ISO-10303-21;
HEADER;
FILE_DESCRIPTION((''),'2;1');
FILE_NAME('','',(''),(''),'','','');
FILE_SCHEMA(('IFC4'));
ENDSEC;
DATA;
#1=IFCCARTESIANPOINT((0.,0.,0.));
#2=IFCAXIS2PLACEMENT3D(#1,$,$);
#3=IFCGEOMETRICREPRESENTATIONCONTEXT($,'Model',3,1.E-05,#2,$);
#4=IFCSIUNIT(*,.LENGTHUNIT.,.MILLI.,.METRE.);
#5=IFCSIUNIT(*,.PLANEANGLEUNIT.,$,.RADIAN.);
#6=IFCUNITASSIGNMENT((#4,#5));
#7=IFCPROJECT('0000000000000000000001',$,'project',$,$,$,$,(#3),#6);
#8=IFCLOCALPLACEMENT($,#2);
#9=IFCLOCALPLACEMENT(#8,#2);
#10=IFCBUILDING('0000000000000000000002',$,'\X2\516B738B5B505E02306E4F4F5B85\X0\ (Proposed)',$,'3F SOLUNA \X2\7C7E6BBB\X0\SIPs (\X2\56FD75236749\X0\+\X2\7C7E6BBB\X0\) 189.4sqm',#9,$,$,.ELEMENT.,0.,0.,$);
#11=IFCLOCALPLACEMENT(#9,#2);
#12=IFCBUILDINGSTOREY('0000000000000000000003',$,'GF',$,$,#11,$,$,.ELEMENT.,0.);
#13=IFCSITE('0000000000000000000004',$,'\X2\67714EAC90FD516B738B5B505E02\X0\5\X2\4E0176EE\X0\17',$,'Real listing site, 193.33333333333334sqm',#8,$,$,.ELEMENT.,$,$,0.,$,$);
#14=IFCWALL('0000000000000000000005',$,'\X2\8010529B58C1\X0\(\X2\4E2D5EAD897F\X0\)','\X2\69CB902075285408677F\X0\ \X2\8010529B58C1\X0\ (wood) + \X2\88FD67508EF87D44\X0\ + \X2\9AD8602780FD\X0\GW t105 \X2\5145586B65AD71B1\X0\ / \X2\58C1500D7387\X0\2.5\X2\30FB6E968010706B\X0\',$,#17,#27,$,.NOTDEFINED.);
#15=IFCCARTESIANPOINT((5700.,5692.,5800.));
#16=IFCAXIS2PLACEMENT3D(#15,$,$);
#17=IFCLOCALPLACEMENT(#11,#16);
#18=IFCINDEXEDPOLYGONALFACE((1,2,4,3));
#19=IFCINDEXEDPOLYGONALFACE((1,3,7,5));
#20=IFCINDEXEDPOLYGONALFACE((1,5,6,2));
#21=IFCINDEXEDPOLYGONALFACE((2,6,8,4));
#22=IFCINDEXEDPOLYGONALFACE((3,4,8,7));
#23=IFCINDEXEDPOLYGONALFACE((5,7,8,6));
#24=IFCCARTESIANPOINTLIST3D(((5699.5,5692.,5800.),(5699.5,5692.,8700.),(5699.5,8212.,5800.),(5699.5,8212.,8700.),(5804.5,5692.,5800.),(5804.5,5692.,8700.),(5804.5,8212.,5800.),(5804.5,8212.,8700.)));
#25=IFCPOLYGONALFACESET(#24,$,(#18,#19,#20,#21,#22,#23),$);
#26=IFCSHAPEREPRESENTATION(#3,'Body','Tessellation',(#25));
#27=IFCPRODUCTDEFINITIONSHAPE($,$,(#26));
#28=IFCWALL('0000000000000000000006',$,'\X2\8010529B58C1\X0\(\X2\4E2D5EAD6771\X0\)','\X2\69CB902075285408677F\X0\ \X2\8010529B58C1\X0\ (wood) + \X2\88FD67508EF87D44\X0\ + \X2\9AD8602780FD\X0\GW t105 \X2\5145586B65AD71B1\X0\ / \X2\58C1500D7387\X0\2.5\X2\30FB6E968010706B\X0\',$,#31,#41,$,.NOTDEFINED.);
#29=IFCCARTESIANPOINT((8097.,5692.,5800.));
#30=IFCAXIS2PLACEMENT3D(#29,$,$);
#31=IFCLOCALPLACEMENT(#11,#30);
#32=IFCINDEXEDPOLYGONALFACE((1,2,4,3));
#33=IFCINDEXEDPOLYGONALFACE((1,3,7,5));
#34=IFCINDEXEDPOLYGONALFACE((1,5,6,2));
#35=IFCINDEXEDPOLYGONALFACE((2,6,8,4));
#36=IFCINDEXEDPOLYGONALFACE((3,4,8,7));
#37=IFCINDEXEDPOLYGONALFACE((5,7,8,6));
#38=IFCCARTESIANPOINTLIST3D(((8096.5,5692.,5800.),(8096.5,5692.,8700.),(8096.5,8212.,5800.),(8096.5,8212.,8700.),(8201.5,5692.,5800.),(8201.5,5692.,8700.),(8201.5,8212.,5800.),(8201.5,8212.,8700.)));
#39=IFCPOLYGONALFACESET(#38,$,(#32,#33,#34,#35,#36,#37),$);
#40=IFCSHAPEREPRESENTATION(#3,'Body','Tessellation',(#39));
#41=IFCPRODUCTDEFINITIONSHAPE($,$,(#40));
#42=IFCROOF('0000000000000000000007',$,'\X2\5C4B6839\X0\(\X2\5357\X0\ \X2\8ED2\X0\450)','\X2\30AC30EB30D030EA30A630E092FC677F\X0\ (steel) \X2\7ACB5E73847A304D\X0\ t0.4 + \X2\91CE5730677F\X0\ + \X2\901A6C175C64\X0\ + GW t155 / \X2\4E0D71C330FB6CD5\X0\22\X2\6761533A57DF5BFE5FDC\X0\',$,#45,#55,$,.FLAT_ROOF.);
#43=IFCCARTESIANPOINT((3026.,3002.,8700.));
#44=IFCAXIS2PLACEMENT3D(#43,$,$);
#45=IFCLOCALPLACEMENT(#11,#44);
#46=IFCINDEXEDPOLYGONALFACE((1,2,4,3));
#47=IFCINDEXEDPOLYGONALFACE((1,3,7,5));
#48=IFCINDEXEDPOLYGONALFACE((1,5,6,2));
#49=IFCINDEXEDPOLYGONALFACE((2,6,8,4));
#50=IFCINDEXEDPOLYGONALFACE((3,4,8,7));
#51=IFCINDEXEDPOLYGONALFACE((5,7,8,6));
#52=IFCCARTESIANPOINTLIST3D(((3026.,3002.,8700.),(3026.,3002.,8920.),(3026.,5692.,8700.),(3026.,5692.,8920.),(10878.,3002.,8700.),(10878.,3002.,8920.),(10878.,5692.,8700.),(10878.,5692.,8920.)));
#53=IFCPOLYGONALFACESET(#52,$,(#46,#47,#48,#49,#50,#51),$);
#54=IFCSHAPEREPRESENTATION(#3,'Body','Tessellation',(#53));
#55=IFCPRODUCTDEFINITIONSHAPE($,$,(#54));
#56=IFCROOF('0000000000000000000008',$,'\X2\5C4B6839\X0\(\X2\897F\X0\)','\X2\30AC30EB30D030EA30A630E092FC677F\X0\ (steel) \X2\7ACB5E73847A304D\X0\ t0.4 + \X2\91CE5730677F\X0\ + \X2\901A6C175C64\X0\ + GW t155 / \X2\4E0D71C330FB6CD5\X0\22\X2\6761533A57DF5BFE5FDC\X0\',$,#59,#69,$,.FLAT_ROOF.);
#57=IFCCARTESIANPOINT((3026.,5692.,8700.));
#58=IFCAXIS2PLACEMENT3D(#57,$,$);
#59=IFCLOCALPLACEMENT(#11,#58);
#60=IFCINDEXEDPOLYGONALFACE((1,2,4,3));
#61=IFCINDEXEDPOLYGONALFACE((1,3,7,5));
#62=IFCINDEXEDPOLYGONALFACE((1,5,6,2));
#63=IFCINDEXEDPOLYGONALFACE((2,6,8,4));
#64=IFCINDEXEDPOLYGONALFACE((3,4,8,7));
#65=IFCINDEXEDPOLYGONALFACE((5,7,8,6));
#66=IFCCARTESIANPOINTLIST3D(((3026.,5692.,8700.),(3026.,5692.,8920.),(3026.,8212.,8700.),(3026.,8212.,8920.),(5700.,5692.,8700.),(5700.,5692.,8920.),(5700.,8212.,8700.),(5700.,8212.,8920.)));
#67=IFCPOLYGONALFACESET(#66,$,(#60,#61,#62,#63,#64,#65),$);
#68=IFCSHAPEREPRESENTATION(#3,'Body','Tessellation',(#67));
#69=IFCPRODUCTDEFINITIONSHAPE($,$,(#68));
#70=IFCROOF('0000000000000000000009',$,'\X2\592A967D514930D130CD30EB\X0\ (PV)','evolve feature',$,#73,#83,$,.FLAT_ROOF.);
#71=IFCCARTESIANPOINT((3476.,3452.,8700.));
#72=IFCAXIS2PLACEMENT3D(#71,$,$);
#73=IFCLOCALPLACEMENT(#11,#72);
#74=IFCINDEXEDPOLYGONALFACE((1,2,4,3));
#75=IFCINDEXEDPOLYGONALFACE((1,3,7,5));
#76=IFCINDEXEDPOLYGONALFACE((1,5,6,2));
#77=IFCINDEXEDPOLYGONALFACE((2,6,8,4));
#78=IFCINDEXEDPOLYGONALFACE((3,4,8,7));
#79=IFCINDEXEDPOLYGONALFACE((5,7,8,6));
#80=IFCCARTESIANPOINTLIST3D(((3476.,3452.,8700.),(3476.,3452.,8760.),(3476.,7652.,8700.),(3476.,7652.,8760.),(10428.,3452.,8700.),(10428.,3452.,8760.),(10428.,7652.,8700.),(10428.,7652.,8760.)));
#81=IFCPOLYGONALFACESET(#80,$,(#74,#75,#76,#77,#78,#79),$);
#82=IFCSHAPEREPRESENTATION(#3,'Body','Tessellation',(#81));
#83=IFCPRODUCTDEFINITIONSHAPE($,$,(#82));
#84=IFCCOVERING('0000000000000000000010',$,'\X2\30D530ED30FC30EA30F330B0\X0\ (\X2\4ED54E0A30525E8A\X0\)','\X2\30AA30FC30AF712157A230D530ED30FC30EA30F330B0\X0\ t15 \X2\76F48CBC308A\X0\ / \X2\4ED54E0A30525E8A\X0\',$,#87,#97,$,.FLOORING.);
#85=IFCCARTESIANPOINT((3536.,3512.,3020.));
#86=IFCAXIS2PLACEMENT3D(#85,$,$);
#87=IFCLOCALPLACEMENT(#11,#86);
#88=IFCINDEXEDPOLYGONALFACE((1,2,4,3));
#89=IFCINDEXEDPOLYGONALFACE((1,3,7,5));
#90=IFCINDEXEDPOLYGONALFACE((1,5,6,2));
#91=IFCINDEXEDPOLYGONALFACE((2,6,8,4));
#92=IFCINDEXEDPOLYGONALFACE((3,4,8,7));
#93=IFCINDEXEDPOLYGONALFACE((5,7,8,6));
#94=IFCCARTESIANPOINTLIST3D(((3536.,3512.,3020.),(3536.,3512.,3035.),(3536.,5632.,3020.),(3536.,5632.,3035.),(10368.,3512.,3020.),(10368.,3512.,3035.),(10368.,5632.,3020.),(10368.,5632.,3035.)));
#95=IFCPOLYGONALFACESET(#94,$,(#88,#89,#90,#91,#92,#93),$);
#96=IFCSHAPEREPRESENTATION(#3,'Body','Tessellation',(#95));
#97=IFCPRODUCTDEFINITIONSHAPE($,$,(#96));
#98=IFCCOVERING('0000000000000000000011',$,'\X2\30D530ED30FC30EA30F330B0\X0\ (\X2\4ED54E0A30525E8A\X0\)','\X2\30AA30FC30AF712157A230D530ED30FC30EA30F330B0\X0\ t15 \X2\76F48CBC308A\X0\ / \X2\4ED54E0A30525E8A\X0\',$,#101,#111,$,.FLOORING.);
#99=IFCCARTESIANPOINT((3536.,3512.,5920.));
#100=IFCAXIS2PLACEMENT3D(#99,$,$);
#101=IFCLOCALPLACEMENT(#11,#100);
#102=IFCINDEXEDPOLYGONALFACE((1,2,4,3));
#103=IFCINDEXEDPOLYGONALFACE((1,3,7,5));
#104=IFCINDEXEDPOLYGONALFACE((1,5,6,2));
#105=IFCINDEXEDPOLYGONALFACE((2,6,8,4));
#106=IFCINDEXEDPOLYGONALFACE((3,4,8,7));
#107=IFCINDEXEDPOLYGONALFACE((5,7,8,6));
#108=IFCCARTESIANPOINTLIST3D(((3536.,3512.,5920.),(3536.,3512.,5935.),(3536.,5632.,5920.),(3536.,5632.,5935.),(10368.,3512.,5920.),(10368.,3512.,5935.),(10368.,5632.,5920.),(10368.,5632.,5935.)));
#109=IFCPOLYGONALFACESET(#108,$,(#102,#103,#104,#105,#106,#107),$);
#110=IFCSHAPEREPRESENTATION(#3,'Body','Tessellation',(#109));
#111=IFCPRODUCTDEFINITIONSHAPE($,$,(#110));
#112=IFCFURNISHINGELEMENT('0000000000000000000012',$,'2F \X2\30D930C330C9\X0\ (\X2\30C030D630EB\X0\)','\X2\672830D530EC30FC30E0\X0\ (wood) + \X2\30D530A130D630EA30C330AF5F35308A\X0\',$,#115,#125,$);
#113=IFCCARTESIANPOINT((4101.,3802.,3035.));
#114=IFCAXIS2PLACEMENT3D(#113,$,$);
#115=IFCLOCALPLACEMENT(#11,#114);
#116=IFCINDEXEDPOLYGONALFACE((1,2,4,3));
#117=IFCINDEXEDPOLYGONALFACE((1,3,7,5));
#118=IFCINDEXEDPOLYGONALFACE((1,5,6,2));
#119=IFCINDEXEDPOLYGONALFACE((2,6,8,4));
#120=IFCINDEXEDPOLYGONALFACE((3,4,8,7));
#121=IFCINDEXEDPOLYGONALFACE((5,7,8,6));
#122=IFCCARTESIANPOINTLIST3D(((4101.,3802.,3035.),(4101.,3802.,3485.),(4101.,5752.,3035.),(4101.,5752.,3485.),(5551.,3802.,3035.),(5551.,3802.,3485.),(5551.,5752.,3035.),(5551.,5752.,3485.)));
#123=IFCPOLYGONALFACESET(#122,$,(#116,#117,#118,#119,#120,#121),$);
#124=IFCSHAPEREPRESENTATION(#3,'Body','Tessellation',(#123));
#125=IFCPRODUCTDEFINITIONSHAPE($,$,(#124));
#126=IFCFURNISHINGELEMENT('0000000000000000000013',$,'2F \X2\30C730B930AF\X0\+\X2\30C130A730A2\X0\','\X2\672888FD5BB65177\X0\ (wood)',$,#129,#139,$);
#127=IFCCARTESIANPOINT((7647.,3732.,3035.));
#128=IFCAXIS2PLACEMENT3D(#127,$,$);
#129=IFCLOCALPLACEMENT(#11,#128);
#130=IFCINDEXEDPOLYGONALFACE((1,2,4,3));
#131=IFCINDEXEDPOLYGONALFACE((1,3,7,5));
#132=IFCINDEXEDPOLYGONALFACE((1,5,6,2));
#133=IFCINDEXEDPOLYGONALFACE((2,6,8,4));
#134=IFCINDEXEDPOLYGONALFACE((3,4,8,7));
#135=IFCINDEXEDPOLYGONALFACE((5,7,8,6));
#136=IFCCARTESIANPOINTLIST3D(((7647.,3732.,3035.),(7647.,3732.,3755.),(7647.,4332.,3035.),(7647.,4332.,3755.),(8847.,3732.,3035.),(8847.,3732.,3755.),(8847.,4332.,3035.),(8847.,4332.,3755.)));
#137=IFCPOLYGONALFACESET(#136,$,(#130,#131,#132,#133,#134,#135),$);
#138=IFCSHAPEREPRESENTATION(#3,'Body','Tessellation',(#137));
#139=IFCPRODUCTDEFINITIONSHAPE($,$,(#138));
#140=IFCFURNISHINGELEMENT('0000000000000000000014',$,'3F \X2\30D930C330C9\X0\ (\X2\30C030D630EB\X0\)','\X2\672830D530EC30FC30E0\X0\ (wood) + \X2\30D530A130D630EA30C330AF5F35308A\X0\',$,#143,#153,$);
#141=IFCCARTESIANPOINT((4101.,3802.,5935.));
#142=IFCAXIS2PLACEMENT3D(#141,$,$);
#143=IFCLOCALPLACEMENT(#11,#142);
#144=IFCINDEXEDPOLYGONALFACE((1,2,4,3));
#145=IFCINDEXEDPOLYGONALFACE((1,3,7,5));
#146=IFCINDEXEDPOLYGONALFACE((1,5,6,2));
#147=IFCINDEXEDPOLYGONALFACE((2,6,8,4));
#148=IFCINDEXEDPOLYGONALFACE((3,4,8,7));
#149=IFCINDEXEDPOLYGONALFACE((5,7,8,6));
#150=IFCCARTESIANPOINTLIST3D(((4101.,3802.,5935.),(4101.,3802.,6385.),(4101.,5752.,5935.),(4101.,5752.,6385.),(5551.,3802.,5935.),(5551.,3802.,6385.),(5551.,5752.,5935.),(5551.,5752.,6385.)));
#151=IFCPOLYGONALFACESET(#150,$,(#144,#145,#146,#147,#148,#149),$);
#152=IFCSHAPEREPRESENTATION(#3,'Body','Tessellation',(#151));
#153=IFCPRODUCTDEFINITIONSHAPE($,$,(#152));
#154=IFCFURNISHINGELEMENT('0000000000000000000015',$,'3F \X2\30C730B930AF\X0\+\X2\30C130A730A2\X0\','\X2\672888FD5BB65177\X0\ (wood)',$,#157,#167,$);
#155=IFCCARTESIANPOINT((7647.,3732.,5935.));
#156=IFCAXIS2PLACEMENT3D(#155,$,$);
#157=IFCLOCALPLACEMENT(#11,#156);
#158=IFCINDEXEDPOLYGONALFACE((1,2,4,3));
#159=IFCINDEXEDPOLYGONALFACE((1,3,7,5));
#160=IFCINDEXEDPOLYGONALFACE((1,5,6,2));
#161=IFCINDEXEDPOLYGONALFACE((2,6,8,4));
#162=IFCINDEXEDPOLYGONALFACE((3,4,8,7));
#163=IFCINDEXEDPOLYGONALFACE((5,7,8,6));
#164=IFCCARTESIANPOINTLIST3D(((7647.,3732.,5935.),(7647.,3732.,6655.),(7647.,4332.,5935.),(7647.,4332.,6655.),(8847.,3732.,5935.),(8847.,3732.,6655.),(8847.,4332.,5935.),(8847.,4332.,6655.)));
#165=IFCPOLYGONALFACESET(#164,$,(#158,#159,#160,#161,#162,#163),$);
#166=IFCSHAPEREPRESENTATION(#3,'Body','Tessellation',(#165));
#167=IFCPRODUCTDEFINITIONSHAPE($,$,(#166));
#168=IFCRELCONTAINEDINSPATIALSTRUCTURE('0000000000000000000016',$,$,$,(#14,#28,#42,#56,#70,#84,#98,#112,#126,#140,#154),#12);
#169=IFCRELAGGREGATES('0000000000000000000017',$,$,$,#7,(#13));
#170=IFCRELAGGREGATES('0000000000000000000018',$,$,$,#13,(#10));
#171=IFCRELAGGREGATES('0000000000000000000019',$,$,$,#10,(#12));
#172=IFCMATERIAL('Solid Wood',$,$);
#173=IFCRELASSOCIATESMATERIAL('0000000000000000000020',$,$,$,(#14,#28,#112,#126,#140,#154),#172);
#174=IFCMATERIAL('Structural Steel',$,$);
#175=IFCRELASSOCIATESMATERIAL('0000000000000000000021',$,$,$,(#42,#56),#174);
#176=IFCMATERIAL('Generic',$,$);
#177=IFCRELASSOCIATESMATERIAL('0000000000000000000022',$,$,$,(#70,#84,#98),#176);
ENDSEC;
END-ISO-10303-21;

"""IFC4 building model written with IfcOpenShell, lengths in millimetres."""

from ifc_helpers import new_model, si_unit, frame, frame_2d, origin, place, context, project, spatial, rectangle, extrude, material, element, save


model = new_model("IFC4")

# Units and contexts
model_context = context("Model", 3, precision=1e-05, world=origin())
ifc_project = project(units=[si_unit("LENGTHUNIT", "METRE", prefix="MILLI"), si_unit("PLANEANGLEUNIT", "RADIAN")], contexts=[model_context])

# Site, building, storey
site_placement = place(None, origin())
site = spatial("IfcSite", under=ifc_project, at=site_placement, Name="東京都八王子市5丁目17", ObjectType="Real listing site, 193.33333333333334sqm", CompositionType="ELEMENT", RefElevation=0.0)
building_placement = place(site_placement, origin())
building = spatial("IfcBuilding", under=site, at=building_placement, Name="八王子市の住宅 (Proposed)", ObjectType="3F SOLUNA 籾殻SIPs (国産杉+籾殻) 189.4sqm", CompositionType="ELEMENT", ElevationOfRefHeight=0.0, ElevationOfTerrain=0.0)
storey_placement = place(building_placement, origin())
storey = spatial("IfcBuildingStorey", under=building, at=storey_placement, Name="GF", CompositionType="ELEMENT", Elevation=0.0)

# Shared definitions
ifc_material_1 = material(Name="Solid Wood")

# Walls
wall_1_placement = place(storey_placement, frame((5700.0, 5692.0, 5800.0)))
element("IfcWall", 1, at=wall_1_placement, inside=storey, material=ifc_material_1, Name="耐力壁(中庭西)", Description="構造用合板 耐力壁 (wood) + 製材軸組 + 高性能GW t105 充填断熱 / 壁倍率2.5・準耐火", PredefinedType="NOTDEFINED", context=model_context, shape_type="SweptSolid", body=[
    extrude(rectangle(XDim=105.0, YDim=2520.0, at=frame_2d((52.0, 1260.0))), frame((5700.0, 5692.0, 5800.0)), (0.0, 0.0, 1.0), 2900.0),
])
wall_2_placement = place(storey_placement, frame((8097.0, 5692.0, 5800.0)))
element("IfcWall", 2, at=wall_2_placement, inside=storey, material=ifc_material_1, Name="耐力壁(中庭東)", Description="構造用合板 耐力壁 (wood) + 製材軸組 + 高性能GW t105 充填断熱 / 壁倍率2.5・準耐火", PredefinedType="NOTDEFINED", context=model_context, shape_type="SweptSolid", body=[
    extrude(rectangle(XDim=105.0, YDim=2520.0, at=frame_2d((52.0, 1260.0))), frame((8097.0, 5692.0, 5800.0)), (0.0, 0.0, 1.0), 2900.0),
])

# Roofs
ifc_material_2 = material(Name="Structural Steel")
roof_1_placement = place(storey_placement, frame((3026.0, 3002.0, 8700.0)))
element("IfcRoof", 3, at=roof_1_placement, inside=storey, material=ifc_material_2, Name="屋根(南 軒450)", Description="ガルバリウム鋼板 (steel) 立平葺き t0.4 + 野地板 + 通気層 + GW t155 / 不燃・法22条区域対応", PredefinedType="FLAT_ROOF", context=model_context, shape_type="SweptSolid", body=[
    extrude(rectangle(XDim=7852.0, YDim=2690.0, at=frame_2d((3926.0, 1345.0))), frame((3026.0, 3002.0, 8700.0)), (0.0, 0.0, 1.0), 220.0),
])
roof_2_placement = place(storey_placement, frame((3026.0, 5692.0, 8700.0)))
element("IfcRoof", 4, at=roof_2_placement, inside=storey, material=ifc_material_2, Name="屋根(西)", Description="ガルバリウム鋼板 (steel) 立平葺き t0.4 + 野地板 + 通気層 + GW t155 / 不燃・法22条区域対応", PredefinedType="FLAT_ROOF", context=model_context, shape_type="SweptSolid", body=[
    extrude(rectangle(XDim=2674.0, YDim=2520.0, at=frame_2d((1337.0, 1260.0))), frame((3026.0, 5692.0, 8700.0)), (0.0, 0.0, 1.0), 220.0),
])
ifc_material_3 = material(Name="Generic")
roof_3_placement = place(storey_placement, frame((3476.0, 3452.0, 8700.0)))
element("IfcRoof", 5, at=roof_3_placement, inside=storey, material=ifc_material_3, Name="太陽光パネル (PV)", Description="evolve feature", PredefinedType="FLAT_ROOF", context=model_context, shape_type="SweptSolid", body=[
    extrude(rectangle(XDim=6952.0, YDim=4200.0, at=frame_2d((3476.0, 2100.0))), frame((3476.0, 3452.0, 8700.0)), (0.0, 0.0, 1.0), 60.0),
])

# Coverings
covering_1_placement = place(storey_placement, frame((3536.0, 3512.0, 3020.0)))
element("IfcCovering", 6, at=covering_1_placement, inside=storey, material=ifc_material_3, Name="フローリング (仕上げ床)", Description="オーク無垢フローリング t15 直貼り / 仕上げ床", PredefinedType="FLOORING", context=model_context, shape_type="SweptSolid", body=[
    extrude(rectangle(XDim=6832.0, YDim=2120.0, at=frame_2d((3416.0, 1060.0))), frame((3536.0, 3512.0, 3020.0)), (0.0, 0.0, 1.0), 15.0),
])
covering_2_placement = place(storey_placement, frame((3536.0, 3512.0, 5920.0)))
element("IfcCovering", 7, at=covering_2_placement, inside=storey, material=ifc_material_3, Name="フローリング (仕上げ床)", Description="オーク無垢フローリング t15 直貼り / 仕上げ床", PredefinedType="FLOORING", context=model_context, shape_type="SweptSolid", body=[
    extrude(rectangle(XDim=6832.0, YDim=2120.0, at=frame_2d((3416.0, 1060.0))), frame((3536.0, 3512.0, 5920.0)), (0.0, 0.0, 1.0), 15.0),
])

# Furnishing elements
furnishing_1_placement = place(storey_placement, frame((4101.0, 3802.0, 3035.0)))
element("IfcFurnishingElement", 8, at=furnishing_1_placement, inside=storey, material=ifc_material_1, Name="2F ベッド (ダブル)", Description="木フレーム (wood) + ファブリック張り", context=model_context, shape_type="SweptSolid", body=[
    extrude(rectangle(XDim=1450.0, YDim=1950.0, at=frame_2d((725.0, 975.0))), frame((4101.0, 3802.0, 3035.0)), (0.0, 0.0, 1.0), 450.0),
])
furnishing_2_placement = place(storey_placement, frame((7647.0, 3732.0, 3035.0)))
element("IfcFurnishingElement", 9, at=furnishing_2_placement, inside=storey, material=ifc_material_1, Name="2F デスク+チェア", Description="木製家具 (wood)", context=model_context, shape_type="SweptSolid", body=[
    extrude(rectangle(XDim=1200.0, YDim=600.0, at=frame_2d((600.0, 300.0))), frame((7647.0, 3732.0, 3035.0)), (0.0, 0.0, 1.0), 720.0),
])
furnishing_3_placement = place(storey_placement, frame((4101.0, 3802.0, 5935.0)))
element("IfcFurnishingElement", 10, at=furnishing_3_placement, inside=storey, material=ifc_material_1, Name="3F ベッド (ダブル)", Description="木フレーム (wood) + ファブリック張り", context=model_context, shape_type="SweptSolid", body=[
    extrude(rectangle(XDim=1450.0, YDim=1950.0, at=frame_2d((725.0, 975.0))), frame((4101.0, 3802.0, 5935.0)), (0.0, 0.0, 1.0), 450.0),
])
furnishing_4_placement = place(storey_placement, frame((7647.0, 3732.0, 5935.0)))
element("IfcFurnishingElement", 11, at=furnishing_4_placement, inside=storey, material=ifc_material_1, Name="3F デスク+チェア", Description="木製家具 (wood)", context=model_context, shape_type="SweptSolid", body=[
    extrude(rectangle(XDim=1200.0, YDim=600.0, at=frame_2d((600.0, 300.0))), frame((7647.0, 3732.0, 5935.0)), (0.0, 0.0, 1.0), 720.0),
])

save(model, "model.ifc")
